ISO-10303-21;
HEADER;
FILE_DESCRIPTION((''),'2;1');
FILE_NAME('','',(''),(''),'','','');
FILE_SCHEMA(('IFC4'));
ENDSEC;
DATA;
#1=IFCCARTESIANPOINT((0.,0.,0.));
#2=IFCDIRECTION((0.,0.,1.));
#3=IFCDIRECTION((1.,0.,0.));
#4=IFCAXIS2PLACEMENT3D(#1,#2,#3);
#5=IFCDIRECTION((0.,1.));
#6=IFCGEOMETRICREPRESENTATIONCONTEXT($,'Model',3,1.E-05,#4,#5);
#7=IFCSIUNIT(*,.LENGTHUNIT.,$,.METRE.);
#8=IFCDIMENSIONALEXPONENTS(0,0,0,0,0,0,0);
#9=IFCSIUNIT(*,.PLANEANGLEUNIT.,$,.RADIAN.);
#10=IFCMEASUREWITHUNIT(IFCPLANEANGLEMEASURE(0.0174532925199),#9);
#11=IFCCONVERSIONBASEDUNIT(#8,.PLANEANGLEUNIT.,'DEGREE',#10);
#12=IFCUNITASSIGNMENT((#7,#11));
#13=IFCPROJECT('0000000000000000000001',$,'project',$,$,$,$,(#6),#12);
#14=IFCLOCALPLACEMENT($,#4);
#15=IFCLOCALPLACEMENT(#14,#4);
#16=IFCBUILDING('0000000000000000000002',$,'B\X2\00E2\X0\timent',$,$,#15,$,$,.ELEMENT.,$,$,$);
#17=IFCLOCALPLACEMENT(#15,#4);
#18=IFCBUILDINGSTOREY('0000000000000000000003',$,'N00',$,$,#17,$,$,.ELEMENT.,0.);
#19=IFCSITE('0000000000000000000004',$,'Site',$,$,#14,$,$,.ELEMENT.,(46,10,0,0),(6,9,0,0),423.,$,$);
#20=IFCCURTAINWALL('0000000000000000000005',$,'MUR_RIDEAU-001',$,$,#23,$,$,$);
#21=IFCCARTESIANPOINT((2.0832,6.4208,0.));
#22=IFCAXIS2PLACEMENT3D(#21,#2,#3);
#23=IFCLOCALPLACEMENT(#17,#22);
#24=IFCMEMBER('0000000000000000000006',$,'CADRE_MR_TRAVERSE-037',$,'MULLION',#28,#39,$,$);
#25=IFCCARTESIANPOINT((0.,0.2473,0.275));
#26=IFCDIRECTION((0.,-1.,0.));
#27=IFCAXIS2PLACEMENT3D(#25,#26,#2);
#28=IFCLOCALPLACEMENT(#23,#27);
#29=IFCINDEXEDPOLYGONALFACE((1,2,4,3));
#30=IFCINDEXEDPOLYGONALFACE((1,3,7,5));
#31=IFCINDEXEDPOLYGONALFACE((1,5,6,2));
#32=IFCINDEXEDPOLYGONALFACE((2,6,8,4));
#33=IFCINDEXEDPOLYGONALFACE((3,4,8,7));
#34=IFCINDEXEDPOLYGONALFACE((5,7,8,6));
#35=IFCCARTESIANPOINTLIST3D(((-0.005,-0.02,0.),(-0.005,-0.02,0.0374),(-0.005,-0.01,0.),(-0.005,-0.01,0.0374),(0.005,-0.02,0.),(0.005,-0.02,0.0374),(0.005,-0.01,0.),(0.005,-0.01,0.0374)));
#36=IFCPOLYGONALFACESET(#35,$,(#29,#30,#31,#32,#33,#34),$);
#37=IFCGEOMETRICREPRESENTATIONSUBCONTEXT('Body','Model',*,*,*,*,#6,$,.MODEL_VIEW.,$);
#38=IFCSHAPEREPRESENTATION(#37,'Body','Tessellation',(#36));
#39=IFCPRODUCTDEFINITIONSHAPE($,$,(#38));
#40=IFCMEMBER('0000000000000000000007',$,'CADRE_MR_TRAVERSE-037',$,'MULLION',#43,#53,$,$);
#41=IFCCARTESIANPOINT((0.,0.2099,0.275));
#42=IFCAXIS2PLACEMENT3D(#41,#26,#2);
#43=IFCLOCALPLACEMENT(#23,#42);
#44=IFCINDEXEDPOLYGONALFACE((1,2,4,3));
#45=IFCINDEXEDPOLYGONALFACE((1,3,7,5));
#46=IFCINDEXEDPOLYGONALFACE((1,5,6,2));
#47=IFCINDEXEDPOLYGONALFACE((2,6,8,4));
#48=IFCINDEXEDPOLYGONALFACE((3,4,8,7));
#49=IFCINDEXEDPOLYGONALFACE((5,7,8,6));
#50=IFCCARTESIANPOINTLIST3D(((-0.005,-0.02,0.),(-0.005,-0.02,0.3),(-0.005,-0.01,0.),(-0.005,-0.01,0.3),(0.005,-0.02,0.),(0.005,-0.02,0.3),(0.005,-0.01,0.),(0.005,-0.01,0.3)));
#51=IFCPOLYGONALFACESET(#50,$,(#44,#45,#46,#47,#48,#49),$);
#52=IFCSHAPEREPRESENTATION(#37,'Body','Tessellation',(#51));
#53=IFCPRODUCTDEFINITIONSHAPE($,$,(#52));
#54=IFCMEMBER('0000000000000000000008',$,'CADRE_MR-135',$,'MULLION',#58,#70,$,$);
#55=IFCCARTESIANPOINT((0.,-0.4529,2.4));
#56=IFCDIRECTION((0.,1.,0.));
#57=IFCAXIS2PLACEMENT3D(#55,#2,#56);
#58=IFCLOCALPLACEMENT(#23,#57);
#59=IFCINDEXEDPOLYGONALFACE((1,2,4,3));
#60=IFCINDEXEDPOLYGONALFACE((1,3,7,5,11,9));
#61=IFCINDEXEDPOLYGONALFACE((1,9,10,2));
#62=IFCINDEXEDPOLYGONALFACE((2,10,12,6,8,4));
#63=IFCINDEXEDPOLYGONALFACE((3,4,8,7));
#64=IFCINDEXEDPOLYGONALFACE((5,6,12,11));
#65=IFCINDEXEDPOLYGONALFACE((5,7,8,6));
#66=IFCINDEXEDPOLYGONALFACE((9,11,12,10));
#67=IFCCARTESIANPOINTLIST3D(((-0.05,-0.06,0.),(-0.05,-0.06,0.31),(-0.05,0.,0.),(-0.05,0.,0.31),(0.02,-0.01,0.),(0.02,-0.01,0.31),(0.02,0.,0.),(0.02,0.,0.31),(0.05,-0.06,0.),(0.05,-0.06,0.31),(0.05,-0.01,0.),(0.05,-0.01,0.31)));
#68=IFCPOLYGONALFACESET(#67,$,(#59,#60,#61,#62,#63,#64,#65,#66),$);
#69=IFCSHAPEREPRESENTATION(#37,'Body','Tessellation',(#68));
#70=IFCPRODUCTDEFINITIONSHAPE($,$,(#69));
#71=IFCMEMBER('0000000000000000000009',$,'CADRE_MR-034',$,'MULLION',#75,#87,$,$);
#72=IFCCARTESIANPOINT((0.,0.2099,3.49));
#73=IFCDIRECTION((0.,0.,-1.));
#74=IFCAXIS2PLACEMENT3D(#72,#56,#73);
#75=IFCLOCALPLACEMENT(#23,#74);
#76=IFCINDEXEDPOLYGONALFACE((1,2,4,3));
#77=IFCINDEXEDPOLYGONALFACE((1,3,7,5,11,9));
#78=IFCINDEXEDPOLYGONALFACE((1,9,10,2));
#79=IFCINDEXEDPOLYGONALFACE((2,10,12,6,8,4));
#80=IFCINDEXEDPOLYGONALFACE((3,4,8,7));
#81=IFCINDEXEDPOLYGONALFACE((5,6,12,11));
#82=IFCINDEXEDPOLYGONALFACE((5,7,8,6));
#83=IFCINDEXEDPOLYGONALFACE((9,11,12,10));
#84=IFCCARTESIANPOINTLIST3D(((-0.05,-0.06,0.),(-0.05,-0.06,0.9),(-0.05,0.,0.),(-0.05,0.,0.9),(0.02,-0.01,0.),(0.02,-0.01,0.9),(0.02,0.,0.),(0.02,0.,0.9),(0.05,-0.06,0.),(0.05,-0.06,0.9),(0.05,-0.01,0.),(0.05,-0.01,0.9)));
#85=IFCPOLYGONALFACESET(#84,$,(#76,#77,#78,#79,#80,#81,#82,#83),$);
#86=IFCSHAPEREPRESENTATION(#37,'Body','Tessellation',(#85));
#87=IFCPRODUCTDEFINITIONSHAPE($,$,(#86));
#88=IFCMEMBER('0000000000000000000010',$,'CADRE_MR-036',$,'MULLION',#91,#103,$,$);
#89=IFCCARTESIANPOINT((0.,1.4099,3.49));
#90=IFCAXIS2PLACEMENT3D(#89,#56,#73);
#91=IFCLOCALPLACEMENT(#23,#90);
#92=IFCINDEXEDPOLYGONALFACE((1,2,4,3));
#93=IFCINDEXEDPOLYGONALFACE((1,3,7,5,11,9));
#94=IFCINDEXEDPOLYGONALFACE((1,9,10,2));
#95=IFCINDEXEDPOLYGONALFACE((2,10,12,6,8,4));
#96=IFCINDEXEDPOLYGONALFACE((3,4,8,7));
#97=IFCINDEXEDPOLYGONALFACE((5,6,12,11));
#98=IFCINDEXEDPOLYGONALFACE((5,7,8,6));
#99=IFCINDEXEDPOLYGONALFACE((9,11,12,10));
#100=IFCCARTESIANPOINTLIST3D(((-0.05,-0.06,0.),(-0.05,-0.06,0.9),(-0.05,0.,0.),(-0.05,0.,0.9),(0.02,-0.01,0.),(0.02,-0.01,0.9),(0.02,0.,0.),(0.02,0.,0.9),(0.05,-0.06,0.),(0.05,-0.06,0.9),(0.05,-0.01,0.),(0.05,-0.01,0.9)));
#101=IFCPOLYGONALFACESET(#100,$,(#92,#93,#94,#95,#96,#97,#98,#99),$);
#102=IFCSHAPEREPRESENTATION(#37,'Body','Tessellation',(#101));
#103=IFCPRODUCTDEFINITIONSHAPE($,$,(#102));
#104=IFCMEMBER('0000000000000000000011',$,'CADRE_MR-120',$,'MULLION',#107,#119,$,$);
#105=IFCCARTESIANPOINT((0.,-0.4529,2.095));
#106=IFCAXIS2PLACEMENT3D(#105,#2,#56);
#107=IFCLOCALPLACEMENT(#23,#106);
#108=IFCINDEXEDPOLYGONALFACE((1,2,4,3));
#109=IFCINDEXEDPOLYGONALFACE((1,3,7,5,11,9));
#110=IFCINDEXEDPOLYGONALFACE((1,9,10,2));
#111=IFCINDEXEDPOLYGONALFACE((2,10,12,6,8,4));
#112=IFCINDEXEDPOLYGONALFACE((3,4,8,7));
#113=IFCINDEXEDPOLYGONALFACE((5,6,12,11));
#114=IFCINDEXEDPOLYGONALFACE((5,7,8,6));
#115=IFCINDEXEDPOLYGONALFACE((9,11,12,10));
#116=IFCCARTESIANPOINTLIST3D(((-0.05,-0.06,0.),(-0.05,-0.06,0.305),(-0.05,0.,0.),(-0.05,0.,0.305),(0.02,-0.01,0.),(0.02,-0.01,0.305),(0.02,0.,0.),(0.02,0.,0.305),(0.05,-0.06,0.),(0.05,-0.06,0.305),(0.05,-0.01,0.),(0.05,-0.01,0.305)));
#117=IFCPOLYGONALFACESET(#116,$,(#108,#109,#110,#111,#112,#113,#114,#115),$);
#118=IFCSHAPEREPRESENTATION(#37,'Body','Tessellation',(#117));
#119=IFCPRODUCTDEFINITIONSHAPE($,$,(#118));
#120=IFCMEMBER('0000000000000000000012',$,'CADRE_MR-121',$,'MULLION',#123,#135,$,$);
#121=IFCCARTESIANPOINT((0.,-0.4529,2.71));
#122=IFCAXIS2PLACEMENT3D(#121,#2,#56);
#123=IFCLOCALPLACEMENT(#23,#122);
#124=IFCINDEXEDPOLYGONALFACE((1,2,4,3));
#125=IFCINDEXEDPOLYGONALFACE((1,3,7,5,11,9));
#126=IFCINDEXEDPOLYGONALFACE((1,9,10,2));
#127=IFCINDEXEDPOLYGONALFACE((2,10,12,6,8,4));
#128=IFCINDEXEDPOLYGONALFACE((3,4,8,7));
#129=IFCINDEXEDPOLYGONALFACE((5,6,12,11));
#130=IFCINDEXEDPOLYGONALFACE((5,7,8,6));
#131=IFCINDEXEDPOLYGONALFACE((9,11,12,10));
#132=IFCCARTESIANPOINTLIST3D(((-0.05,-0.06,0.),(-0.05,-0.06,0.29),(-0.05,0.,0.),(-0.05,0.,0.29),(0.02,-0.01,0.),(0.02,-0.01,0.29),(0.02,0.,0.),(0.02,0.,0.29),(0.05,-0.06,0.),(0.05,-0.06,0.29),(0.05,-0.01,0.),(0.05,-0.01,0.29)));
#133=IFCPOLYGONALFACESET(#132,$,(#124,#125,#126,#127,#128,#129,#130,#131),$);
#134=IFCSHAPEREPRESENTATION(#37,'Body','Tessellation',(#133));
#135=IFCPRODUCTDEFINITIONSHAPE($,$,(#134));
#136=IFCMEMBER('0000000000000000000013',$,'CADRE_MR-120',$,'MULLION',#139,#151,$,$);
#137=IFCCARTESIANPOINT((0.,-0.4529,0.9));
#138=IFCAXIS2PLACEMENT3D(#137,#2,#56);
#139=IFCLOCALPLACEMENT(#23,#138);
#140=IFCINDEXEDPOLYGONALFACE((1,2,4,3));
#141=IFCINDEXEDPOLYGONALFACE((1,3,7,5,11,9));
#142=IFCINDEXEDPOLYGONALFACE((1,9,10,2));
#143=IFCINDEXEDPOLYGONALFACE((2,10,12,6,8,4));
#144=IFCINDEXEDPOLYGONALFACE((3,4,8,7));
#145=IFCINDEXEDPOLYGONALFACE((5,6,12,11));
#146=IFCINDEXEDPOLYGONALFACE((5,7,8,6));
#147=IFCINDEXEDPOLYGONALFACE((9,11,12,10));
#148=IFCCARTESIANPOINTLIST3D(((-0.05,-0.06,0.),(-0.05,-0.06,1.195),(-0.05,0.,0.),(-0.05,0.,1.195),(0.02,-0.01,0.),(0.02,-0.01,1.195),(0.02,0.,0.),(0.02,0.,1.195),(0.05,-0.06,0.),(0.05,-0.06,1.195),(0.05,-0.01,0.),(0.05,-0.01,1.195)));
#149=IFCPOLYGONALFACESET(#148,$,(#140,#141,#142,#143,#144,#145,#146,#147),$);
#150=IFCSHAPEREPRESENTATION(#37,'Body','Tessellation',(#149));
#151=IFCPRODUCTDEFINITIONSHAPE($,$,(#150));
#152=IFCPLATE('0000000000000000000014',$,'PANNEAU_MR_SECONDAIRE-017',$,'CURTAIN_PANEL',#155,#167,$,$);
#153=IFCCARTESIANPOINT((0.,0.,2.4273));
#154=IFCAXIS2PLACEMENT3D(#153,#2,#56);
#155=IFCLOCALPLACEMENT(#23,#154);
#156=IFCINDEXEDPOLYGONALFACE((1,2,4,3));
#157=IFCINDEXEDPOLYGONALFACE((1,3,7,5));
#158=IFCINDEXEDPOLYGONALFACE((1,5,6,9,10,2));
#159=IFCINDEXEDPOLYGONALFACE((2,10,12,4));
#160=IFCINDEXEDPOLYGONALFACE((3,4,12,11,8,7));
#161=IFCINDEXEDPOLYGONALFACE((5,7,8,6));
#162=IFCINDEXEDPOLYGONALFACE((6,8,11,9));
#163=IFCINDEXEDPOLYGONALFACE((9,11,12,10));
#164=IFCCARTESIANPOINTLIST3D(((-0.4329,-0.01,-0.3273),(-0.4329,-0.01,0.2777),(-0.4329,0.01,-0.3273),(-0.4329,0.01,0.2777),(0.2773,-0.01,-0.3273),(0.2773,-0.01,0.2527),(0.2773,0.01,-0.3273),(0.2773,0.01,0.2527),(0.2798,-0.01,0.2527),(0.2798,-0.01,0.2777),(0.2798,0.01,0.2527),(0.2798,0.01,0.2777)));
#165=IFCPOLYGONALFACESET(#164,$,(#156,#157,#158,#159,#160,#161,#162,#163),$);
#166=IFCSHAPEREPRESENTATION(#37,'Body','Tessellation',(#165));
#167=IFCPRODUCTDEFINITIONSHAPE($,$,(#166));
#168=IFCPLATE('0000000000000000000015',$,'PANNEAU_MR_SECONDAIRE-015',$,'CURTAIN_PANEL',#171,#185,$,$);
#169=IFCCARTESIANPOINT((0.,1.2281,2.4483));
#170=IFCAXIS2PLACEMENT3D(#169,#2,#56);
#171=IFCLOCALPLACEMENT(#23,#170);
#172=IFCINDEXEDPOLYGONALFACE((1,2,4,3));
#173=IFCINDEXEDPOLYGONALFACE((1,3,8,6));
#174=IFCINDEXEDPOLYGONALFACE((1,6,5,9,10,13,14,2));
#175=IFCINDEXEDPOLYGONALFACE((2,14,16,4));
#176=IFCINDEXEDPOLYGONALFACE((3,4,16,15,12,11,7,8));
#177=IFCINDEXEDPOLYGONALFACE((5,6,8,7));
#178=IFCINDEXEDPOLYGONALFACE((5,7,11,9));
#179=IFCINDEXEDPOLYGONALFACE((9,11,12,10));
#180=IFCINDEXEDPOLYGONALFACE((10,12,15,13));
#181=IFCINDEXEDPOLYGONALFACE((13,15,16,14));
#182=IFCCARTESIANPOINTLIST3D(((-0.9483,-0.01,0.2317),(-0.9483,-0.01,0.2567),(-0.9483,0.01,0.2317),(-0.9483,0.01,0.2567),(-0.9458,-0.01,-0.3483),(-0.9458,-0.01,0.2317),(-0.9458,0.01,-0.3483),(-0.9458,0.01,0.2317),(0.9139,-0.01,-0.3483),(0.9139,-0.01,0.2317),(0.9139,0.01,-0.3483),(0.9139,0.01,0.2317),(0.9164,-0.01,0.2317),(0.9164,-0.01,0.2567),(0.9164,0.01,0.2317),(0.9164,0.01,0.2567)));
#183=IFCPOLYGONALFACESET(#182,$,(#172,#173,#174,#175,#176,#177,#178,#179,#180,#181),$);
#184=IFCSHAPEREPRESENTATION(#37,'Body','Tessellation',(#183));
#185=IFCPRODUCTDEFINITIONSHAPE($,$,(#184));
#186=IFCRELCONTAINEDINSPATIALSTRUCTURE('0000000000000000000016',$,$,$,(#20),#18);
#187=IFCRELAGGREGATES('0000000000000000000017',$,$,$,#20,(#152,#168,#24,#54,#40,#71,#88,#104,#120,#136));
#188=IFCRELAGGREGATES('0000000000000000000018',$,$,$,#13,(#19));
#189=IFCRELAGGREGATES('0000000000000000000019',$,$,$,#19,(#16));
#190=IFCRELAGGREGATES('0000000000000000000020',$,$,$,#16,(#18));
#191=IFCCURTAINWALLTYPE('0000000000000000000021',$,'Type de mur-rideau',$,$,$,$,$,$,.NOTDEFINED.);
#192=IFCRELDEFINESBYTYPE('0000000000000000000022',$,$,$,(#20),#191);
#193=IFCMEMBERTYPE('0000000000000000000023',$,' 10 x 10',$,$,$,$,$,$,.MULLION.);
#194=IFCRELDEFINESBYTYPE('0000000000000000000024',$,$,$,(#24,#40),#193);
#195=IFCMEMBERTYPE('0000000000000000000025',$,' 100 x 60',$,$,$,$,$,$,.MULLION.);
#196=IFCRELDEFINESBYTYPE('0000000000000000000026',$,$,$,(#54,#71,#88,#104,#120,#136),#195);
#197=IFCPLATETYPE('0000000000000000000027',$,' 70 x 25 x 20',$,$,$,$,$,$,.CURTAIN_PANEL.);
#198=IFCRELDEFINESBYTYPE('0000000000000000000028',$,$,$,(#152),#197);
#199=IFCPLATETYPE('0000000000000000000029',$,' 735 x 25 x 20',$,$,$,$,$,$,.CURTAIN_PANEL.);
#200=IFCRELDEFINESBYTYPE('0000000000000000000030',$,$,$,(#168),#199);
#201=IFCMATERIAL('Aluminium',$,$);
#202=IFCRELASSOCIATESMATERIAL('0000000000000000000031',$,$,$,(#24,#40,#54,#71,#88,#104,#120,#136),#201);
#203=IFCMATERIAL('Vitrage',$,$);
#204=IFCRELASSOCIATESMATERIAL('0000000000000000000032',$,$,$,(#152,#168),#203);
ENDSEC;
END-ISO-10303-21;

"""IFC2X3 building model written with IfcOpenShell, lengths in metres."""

from ifc_helpers import new_model, entity, si_unit, converted_unit, direction, frame, origin_with_axes, place, context, subcontext, project, spatial, polyline, outline, extrude, material, type_object, element, aggregate, save


model = new_model("IFC2X3")

# Units and contexts
model_context = context("Model", 3, precision=1e-05, world=origin_with_axes(), true_north=direction((0.0, 1.0)))
body_context = subcontext(model_context, "Body", "Model", "MODEL_VIEW")
ifc_project = project(units=[si_unit("LENGTHUNIT", "METRE"), converted_unit("PLANEANGLEUNIT", "DEGREE", entity("IfcPlaneAngleMeasure", 0.0174532925199), si_unit("PLANEANGLEUNIT", "RADIAN"), dimensions=[0, 0, 0, 0, 0, 0, 0])], contexts=[model_context])

# Site, building, storey
site_placement = place(None, origin_with_axes())
site = spatial("IfcSite", under=ifc_project, at=site_placement, Name="Site", CompositionType="ELEMENT", RefLatitude=(46, 10, 0, 0), RefLongitude=(6, 9, 0, 0), RefElevation=423.0)
building_placement = place(site_placement, origin_with_axes())
building = spatial("IfcBuilding", under=site, at=building_placement, Name="Bâtiment", CompositionType="ELEMENT")
storey_placement = place(building_placement, origin_with_axes())
storey = spatial("IfcBuildingStorey", under=building, at=storey_placement, Name="N00", CompositionType="ELEMENT", Elevation=0.0)

# Curtain wall, members, plates
curtain_wall_type = type_object("IfcCurtainWallType", Name="Type de mur-rideau", PredefinedType="NOTDEFINED")
curtain_wall_placement = place(storey_placement, frame((2.0832, 6.4208, 0.0), z_axis=(0.0, 0.0, 1.0), x_axis=(1.0, 0.0, 0.0)))
curtain_wall = element("IfcCurtainWall", 1, at=curtain_wall_placement, inside=storey, type_object=curtain_wall_type, Name="MUR_RIDEAU-001")
ifc_material_1 = material(Name="Aluminium")
member_type_1 = type_object("IfcMemberType", Name=" 10 x 10", PredefinedType="MULLION")
member_1_placement = place(curtain_wall_placement, frame((0.0, 0.2473, 0.275), z_axis=(0.0, -1.0, 0.0), x_axis=(0.0, 0.0, 1.0)))
member_1 = element("IfcMember", 2, at=member_1_placement, type_object=member_type_1, material=ifc_material_1, Name="CADRE_MR_TRAVERSE-037", ObjectType="MULLION", context=body_context, shape_type="SweptSolid", body=[
    extrude(outline(polyline([(-0.02, -0.005), (-0.01, -0.005), (-0.01, 0.005), (-0.02, 0.005), (-0.02, -0.005)])), frame((0.0, 0.0, 0.0), z_axis=(0.0, 0.0, 1.0), x_axis=(0.0, 1.0, 0.0)), (0.0, 0.0, 1.0), 0.0374),
])
member_2_placement = place(curtain_wall_placement, frame((0.0, 0.2099, 0.275), z_axis=(0.0, -1.0, 0.0), x_axis=(0.0, 0.0, 1.0)))
member_2 = element("IfcMember", 3, at=member_2_placement, type_object=member_type_1, material=ifc_material_1, Name="CADRE_MR_TRAVERSE-037", ObjectType="MULLION", context=body_context, shape_type="SweptSolid", body=[
    extrude(outline(polyline([(-0.02, -0.005), (-0.01, -0.005), (-0.01, 0.005), (-0.02, 0.005), (-0.02, -0.005)])), frame((0.0, 0.0, 0.0), z_axis=(0.0, 0.0, 1.0), x_axis=(0.0, 1.0, 0.0)), (0.0, 0.0, 1.0), 0.3),
])
member_type_2 = type_object("IfcMemberType", Name=" 100 x 60", PredefinedType="MULLION")
member_3_placement = place(curtain_wall_placement, frame((0.0, -0.4529, 2.4), z_axis=(0.0, 0.0, 1.0), x_axis=(0.0, 1.0, 0.0)))
member_3 = element("IfcMember", 4, at=member_3_placement, type_object=member_type_2, material=ifc_material_1, Name="CADRE_MR-135", ObjectType="MULLION", context=body_context, shape_type="SweptSolid", body=[
    extrude(outline(polyline([(0.01, 0.02), (0.0, 0.02), (0.0, -0.05), (0.06, -0.05), (0.06, 0.05), (0.01, 0.05), (0.01, 0.02)])), frame((0.0, 0.0, 0.0), z_axis=(0.0, 0.0, 1.0), x_axis=(0.0, -1.0, 0.0)), (0.0, 0.0, 1.0), 0.31),
])
member_4_placement = place(curtain_wall_placement, frame((0.0, 0.2099, 3.49), z_axis=(0.0, 1.0, 0.0), x_axis=(0.0, 0.0, -1.0)))
member_4 = element("IfcMember", 5, at=member_4_placement, type_object=member_type_2, material=ifc_material_1, Name="CADRE_MR-034", ObjectType="MULLION", context=body_context, shape_type="SweptSolid", body=[
    extrude(outline(polyline([(0.01, 0.02), (0.0, 0.02), (0.0, -0.05), (0.06, -0.05), (0.06, 0.05), (0.01, 0.05), (0.01, 0.02)])), frame((0.0, 0.0, 0.0), z_axis=(0.0, 0.0, 1.0), x_axis=(0.0, -1.0, 0.0)), (0.0, 0.0, 1.0), 0.9),
])
member_5_placement = place(curtain_wall_placement, frame((0.0, 1.4099, 3.49), z_axis=(0.0, 1.0, 0.0), x_axis=(0.0, 0.0, -1.0)))
member_5 = element("IfcMember", 6, at=member_5_placement, type_object=member_type_2, material=ifc_material_1, Name="CADRE_MR-036", ObjectType="MULLION", context=body_context, shape_type="SweptSolid", body=[
    extrude(outline(polyline([(0.01, 0.02), (0.0, 0.02), (0.0, -0.05), (0.06, -0.05), (0.06, 0.05), (0.01, 0.05), (0.01, 0.02)])), frame((0.0, 0.0, 0.0), z_axis=(0.0, 0.0, 1.0), x_axis=(0.0, -1.0, 0.0)), (0.0, 0.0, 1.0), 0.9),
])
member_6_placement = place(curtain_wall_placement, frame((0.0, -0.4529, 2.095), z_axis=(0.0, 0.0, 1.0), x_axis=(0.0, 1.0, 0.0)))
member_6 = element("IfcMember", 7, at=member_6_placement, type_object=member_type_2, material=ifc_material_1, Name="CADRE_MR-120", ObjectType="MULLION", context=body_context, shape_type="SweptSolid", body=[
    extrude(outline(polyline([(0.01, 0.02), (0.0, 0.02), (0.0, -0.05), (0.06, -0.05), (0.06, 0.05), (0.01, 0.05), (0.01, 0.02)])), frame((0.0, 0.0, 0.0), z_axis=(0.0, 0.0, 1.0), x_axis=(0.0, -1.0, 0.0)), (0.0, 0.0, 1.0), 0.305),
])
member_7_placement = place(curtain_wall_placement, frame((0.0, -0.4529, 2.71), z_axis=(0.0, 0.0, 1.0), x_axis=(0.0, 1.0, 0.0)))
member_7 = element("IfcMember", 8, at=member_7_placement, type_object=member_type_2, material=ifc_material_1, Name="CADRE_MR-121", ObjectType="MULLION", context=body_context, shape_type="SweptSolid", body=[
    extrude(outline(polyline([(0.01, 0.02), (0.0, 0.02), (0.0, -0.05), (0.06, -0.05), (0.06, 0.05), (0.01, 0.05), (0.01, 0.02)])), frame((0.0, 0.0, 0.0), z_axis=(0.0, 0.0, 1.0), x_axis=(0.0, -1.0, 0.0)), (0.0, 0.0, 1.0), 0.29),
])
member_8_placement = place(curtain_wall_placement, frame((0.0, -0.4529, 0.9), z_axis=(0.0, 0.0, 1.0), x_axis=(0.0, 1.0, 0.0)))
member_8 = element("IfcMember", 9, at=member_8_placement, type_object=member_type_2, material=ifc_material_1, Name="CADRE_MR-120", ObjectType="MULLION", context=body_context, shape_type="SweptSolid", body=[
    extrude(outline(polyline([(0.01, 0.02), (0.0, 0.02), (0.0, -0.05), (0.06, -0.05), (0.06, 0.05), (0.01, 0.05), (0.01, 0.02)])), frame((0.0, 0.0, 0.0), z_axis=(0.0, 0.0, 1.0), x_axis=(0.0, -1.0, 0.0)), (0.0, 0.0, 1.0), 1.195),
])
ifc_material_2 = material(Name="Vitrage")
plate_type_1 = type_object("IfcPlateType", Name=" 70 x 25 x 20", PredefinedType="CURTAIN_PANEL")
plate_1_placement = place(curtain_wall_placement, frame((0.0, 0.0, 2.4273), z_axis=(0.0, 0.0, 1.0), x_axis=(0.0, 1.0, 0.0)))
plate_1 = element("IfcPlate", 10, at=plate_1_placement, type_object=plate_type_1, material=ifc_material_2, Name="PANNEAU_MR_SECONDAIRE-017", ObjectType="CURTAIN_PANEL", context=body_context, shape_type="SweptSolid", body=[
    extrude(outline(polyline([(-0.4329, -0.2777), (0.2798, -0.2777), (0.2798, -0.2527), (0.2773, -0.2527), (0.2773, 0.3273), (-0.4329, 0.3273), (-0.4329, -0.2777)])), frame((0.0, -0.01, 0.0), z_axis=(0.0, 1.0, 0.0), x_axis=(1.0, 0.0, 0.0)), (0.0, 0.0, 1.0), 0.02),
])
plate_type_2 = type_object("IfcPlateType", Name=" 735 x 25 x 20", PredefinedType="CURTAIN_PANEL")
plate_2_placement = place(curtain_wall_placement, frame((0.0, 1.2281, 2.4483), z_axis=(0.0, 0.0, 1.0), x_axis=(0.0, 1.0, 0.0)))
plate_2 = element("IfcPlate", 11, at=plate_2_placement, type_object=plate_type_2, material=ifc_material_2, Name="PANNEAU_MR_SECONDAIRE-015", ObjectType="CURTAIN_PANEL", context=body_context, shape_type="SweptSolid", body=[
    extrude(outline(polyline([(-0.9483, -0.2567), (0.9164, -0.2567), (0.9164, -0.2317), (0.9139, -0.2317), (0.9139, 0.3483), (-0.9458, 0.3483), (-0.9458, -0.2317), (-0.9483, -0.2317), (-0.9483, -0.2567)])), frame((0.0, -0.01, 0.0), z_axis=(0.0, 1.0, 0.0), x_axis=(1.0, 0.0, 0.0)), (0.0, 0.0, 1.0), 0.02),
])
aggregate(curtain_wall, [plate_1, plate_2, member_1, member_3, member_2, member_4, member_5, member_6, member_7, member_8])

save(model, "model.ifc")
